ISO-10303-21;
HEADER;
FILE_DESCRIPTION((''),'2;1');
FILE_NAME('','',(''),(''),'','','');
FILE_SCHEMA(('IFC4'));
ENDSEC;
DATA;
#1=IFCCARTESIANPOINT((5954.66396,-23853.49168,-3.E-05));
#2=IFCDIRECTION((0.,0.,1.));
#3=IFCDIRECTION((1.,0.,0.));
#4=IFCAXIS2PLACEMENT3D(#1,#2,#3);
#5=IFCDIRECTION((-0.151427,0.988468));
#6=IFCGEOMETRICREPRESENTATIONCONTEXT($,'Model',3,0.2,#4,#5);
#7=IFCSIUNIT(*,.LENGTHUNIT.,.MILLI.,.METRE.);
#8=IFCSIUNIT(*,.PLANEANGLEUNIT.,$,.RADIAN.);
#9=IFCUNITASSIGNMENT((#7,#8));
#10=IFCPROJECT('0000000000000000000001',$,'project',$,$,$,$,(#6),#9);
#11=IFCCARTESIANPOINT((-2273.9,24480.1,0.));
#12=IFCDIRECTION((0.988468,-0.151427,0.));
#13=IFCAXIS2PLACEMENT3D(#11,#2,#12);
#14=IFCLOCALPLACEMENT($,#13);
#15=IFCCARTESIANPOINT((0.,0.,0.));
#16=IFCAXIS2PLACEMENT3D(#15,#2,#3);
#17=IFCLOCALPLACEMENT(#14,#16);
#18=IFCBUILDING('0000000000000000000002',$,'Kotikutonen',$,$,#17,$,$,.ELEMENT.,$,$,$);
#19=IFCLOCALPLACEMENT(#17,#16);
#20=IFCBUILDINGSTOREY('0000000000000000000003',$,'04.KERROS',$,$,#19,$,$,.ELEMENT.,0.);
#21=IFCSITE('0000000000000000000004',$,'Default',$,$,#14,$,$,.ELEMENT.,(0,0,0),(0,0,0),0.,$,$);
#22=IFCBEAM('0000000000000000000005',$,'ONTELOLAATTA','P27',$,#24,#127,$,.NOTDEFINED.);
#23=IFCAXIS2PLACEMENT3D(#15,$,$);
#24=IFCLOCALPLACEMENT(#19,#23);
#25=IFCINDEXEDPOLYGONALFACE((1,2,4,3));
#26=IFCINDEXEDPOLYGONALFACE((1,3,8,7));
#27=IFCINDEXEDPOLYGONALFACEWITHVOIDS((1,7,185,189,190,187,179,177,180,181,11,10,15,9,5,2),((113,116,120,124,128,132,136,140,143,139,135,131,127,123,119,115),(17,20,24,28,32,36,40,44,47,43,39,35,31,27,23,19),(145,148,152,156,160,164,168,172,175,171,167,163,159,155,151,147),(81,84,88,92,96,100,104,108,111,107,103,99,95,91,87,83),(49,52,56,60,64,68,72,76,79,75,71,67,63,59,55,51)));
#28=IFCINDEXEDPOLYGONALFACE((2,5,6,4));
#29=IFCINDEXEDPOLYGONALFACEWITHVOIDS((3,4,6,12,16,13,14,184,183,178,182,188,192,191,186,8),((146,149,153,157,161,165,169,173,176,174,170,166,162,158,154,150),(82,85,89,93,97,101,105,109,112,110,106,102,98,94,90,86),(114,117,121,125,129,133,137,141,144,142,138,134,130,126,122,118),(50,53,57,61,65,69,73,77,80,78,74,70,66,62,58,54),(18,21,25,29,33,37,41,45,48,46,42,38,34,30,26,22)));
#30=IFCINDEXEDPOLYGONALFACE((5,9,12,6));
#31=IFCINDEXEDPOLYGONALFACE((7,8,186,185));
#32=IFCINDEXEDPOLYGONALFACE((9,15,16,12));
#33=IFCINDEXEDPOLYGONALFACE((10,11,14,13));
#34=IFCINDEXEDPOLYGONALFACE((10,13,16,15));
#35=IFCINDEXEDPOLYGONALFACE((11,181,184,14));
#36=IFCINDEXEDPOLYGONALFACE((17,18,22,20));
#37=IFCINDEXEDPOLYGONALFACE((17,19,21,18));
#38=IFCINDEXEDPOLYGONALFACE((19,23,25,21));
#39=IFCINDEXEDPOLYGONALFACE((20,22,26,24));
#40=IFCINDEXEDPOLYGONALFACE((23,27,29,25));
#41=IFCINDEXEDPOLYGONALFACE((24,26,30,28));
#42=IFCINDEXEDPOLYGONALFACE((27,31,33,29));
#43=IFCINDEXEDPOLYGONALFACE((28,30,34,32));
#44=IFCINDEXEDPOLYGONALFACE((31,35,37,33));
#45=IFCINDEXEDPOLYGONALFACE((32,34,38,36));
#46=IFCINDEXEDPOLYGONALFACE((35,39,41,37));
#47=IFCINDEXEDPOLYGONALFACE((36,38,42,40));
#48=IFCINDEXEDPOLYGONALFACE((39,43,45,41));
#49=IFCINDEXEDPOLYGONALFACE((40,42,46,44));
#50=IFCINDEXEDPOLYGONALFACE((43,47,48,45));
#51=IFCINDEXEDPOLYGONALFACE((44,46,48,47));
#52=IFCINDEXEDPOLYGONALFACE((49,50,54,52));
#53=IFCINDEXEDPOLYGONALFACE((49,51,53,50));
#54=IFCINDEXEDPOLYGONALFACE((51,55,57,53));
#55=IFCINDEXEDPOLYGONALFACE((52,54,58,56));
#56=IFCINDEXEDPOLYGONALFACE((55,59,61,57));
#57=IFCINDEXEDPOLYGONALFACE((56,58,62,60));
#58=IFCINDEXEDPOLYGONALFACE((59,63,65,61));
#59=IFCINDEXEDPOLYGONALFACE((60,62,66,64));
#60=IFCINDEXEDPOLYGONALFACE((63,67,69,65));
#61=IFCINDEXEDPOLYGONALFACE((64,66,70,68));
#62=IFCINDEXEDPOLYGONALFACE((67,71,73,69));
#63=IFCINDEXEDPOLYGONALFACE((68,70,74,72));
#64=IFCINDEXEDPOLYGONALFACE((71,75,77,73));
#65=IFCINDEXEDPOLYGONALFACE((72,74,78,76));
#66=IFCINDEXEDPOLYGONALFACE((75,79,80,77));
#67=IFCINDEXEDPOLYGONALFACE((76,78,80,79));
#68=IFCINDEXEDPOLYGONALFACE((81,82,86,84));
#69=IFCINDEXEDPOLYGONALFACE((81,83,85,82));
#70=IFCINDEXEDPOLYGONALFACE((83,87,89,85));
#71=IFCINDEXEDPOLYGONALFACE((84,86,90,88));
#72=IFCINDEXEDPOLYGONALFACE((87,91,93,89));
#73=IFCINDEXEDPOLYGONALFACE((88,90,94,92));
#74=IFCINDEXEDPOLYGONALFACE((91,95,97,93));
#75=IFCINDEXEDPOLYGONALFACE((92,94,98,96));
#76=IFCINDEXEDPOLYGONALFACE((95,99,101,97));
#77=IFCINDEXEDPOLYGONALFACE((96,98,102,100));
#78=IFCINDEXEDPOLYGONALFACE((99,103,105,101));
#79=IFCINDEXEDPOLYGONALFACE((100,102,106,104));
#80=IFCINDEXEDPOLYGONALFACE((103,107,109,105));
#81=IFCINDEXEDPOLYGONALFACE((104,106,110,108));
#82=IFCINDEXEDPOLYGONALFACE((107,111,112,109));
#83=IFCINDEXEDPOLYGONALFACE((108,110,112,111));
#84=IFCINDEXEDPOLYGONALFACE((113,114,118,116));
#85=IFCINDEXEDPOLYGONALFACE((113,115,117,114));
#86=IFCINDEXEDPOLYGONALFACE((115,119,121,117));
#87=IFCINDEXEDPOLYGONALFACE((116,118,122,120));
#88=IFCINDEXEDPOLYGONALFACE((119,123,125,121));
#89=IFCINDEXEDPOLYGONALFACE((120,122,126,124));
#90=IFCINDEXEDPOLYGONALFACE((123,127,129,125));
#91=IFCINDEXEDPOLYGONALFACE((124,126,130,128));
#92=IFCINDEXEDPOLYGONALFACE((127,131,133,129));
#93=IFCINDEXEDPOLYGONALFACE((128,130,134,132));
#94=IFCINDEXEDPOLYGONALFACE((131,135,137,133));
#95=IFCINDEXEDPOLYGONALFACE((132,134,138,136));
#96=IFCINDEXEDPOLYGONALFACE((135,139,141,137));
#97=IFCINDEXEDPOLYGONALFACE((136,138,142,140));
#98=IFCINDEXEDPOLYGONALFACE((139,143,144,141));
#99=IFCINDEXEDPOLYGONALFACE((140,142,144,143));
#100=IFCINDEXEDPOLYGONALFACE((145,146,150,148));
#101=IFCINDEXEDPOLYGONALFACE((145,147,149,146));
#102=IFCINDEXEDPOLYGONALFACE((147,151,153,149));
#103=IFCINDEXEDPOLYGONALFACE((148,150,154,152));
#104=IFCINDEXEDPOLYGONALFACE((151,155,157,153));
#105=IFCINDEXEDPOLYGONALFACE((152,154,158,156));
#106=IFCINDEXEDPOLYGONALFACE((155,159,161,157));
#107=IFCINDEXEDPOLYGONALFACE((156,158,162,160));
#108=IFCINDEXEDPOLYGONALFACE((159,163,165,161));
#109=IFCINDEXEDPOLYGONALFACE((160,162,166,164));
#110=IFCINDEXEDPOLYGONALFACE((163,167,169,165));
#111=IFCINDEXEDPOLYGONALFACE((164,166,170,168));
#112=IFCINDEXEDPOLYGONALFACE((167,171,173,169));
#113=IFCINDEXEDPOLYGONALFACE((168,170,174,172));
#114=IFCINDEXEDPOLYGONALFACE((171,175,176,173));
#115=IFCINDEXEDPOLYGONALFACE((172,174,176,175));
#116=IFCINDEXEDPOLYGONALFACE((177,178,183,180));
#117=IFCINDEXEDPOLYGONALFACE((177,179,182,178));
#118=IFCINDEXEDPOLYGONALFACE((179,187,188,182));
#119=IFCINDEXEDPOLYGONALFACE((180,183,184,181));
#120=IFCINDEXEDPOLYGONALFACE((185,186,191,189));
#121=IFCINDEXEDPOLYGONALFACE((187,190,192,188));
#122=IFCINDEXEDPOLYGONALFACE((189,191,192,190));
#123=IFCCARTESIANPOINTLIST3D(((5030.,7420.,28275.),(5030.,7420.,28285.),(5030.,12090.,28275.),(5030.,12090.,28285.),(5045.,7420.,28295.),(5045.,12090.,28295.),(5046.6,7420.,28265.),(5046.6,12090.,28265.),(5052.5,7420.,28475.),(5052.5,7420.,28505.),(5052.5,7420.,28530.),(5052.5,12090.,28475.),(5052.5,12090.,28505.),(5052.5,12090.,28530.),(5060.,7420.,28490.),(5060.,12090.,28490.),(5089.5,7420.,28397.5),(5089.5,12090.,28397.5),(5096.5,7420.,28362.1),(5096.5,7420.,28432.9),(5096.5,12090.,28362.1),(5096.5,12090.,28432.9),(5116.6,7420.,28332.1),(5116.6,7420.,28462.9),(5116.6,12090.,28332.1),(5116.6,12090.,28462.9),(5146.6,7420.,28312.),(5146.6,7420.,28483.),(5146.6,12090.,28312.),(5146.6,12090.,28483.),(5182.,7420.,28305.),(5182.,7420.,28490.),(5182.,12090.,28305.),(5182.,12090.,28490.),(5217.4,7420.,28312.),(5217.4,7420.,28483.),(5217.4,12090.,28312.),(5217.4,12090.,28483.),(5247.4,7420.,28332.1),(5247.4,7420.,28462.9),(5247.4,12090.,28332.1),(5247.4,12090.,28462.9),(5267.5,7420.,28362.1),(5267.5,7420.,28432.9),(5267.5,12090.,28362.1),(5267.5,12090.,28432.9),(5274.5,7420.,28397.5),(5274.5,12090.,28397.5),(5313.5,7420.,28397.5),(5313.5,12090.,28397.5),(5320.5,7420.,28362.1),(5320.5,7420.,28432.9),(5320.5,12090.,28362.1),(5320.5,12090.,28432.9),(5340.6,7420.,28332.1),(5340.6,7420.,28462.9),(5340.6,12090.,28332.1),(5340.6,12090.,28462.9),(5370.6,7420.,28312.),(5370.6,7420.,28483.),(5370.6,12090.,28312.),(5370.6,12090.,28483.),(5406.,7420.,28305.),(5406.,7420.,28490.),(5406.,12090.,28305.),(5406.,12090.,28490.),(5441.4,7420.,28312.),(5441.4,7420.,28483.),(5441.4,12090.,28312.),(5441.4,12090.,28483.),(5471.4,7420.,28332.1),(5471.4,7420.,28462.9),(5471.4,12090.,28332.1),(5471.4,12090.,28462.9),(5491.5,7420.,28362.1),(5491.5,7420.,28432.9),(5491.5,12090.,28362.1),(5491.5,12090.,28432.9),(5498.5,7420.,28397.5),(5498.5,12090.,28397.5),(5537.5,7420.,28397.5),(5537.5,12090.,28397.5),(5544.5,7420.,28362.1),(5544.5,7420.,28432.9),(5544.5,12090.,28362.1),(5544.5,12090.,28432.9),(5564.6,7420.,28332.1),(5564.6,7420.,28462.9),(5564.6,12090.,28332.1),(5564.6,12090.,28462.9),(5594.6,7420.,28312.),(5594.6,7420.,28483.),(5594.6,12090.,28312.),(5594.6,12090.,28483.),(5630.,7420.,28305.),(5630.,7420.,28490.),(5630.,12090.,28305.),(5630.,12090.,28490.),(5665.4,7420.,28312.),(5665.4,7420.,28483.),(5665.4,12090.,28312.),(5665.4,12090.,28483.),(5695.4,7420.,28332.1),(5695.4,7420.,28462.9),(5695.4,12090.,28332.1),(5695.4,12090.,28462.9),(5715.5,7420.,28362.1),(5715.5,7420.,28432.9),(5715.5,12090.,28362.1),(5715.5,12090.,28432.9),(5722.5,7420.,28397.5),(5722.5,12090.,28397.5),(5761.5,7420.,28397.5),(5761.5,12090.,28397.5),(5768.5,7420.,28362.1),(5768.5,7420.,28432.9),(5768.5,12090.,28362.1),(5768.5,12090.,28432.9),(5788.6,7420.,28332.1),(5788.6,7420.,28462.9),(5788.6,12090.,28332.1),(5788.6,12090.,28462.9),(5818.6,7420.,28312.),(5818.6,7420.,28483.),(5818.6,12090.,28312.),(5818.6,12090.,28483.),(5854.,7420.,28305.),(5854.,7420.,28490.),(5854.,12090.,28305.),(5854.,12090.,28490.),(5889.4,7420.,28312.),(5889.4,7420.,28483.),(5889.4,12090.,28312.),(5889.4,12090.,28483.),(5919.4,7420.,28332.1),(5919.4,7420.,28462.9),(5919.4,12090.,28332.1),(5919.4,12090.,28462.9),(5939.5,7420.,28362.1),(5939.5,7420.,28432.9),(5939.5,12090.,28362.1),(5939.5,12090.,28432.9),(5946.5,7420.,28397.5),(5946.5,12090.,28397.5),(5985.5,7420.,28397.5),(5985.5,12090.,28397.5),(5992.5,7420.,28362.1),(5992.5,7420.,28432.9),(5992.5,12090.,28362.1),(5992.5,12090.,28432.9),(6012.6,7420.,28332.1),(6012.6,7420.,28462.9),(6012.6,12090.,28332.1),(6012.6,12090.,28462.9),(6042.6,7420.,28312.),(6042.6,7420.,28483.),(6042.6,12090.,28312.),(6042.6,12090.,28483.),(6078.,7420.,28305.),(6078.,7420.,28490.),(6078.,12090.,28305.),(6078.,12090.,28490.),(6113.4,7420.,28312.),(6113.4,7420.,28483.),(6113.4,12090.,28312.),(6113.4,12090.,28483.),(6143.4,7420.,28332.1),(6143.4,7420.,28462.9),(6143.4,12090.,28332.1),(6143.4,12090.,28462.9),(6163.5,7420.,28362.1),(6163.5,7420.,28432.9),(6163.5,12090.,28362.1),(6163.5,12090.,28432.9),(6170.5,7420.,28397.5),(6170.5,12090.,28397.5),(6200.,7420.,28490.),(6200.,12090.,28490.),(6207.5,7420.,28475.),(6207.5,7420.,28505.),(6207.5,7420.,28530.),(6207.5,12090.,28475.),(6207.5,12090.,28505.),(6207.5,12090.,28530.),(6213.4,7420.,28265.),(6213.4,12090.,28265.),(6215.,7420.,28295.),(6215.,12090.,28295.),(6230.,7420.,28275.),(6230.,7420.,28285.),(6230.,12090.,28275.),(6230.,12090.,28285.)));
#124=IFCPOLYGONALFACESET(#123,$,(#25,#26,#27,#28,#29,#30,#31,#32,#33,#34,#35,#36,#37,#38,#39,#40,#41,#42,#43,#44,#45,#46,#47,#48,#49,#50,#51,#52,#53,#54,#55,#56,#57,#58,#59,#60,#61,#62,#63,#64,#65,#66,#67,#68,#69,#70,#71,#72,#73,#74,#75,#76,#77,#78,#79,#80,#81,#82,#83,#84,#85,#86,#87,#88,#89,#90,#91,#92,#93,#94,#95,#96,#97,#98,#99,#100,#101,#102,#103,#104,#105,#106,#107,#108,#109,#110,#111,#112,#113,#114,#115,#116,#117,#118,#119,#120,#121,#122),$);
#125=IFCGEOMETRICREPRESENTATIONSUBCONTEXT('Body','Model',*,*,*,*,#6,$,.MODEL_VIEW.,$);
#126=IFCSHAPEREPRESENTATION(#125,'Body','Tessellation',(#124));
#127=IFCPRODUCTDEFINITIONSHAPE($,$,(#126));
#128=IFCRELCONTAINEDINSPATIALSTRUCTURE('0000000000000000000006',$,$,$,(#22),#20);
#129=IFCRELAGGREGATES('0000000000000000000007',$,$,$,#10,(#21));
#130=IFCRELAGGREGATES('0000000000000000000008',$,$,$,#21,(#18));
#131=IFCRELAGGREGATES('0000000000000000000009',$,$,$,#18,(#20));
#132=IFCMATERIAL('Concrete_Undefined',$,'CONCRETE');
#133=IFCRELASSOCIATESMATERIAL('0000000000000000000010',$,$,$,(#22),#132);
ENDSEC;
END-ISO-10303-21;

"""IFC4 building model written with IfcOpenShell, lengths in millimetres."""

from ifc_helpers import new_model, si_unit, direction, frame, origin_with_axes, place, context, subcontext, project, spatial, line, indexed_curve, outline, extrude, material, element, save


model = new_model("IFC4")

# Units and contexts
model_context = context("Model", 3, precision=0.2, world=frame((5954.66396, -23853.49168, -3e-05), z_axis=(0.0, 0.0, 1.0), x_axis=(1.0, 0.0, 0.0)), true_north=direction((-0.151427, 0.988468)))
body_context = subcontext(model_context, "Body", "Model", "MODEL_VIEW")
ifc_project = project(units=[si_unit("LENGTHUNIT", "METRE", prefix="MILLI"), si_unit("PLANEANGLEUNIT", "RADIAN")], contexts=[model_context])

# Site, building, storey
site_placement = place(None, frame((-2273.9, 24480.1, 0.0), z_axis=(0.0, 0.0, 1.0), x_axis=(0.988468, -0.151427, 0.0)))
site = spatial("IfcSite", under=ifc_project, at=site_placement, Name="Default", CompositionType="ELEMENT", RefLatitude=(0, 0, 0), RefLongitude=(0, 0, 0), RefElevation=0.0)
building_placement = place(site_placement, origin_with_axes())
building = spatial("IfcBuilding", under=site, at=building_placement, Name="Kotikutonen", CompositionType="ELEMENT")
storey_placement = place(building_placement, origin_with_axes())
storey = spatial("IfcBuildingStorey", under=building, at=storey_placement, Name="04.KERROS", CompositionType="ELEMENT", Elevation=0.0)

# Beam
ifc_material_1 = material(Name="Concrete_Undefined", Category="CONCRETE")
beam_1_placement = place(storey_placement, frame((5630.0, 12090.0, 28397.5), z_axis=(-1.0, 0.0, 0.0), x_axis=(0.0, -1.0, 0.0)))
element("IfcBeam", 1, at=beam_1_placement, inside=storey, material=ifc_material_1, Name="ONTELOLAATTA", Description="P27", PredefinedType="NOTDEFINED", context=body_context, shape_type="SolidModel", body=[
    extrude(outline(indexed_curve([(-600.0, -122.5), (-583.4, -132.5), (583.4, -132.5), (600.0, -122.5), (600.0, -112.5), (585.0, -102.5), (577.5, 77.5), (570.0, 92.5), (577.5, 107.5), (577.5, 132.5), (-577.5, 132.5), (-577.5, 107.5), (-570.0, 92.5), (-577.5, 77.5), (-585.0, -102.5), (-600.0, -112.5)], segments=[line(1, 2, 3, 4, 5, 6, 7, 8, 9, 10, 11, 12, 13, 14, 15, 16, 1)]), holes=[indexed_curve([(-448.0, -92.5), (-483.4, -85.5), (-513.4, -65.4), (-533.5, -35.4), (-540.5, 0.0), (-533.5, 35.4), (-513.4, 65.4), (-483.4, 85.5), (-448.0, 92.5), (-412.6, 85.5), (-382.6, 65.4), (-362.5, 35.4), (-355.5, 0.0), (-362.5, -35.4), (-382.6, -65.4), (-412.6, -85.5)], segments=[line(1, 2, 3, 4, 5, 6, 7, 8, 9, 10, 11, 12, 13, 14, 15, 16, 1)]), indexed_curve([(-224.0, -92.5), (-259.4, -85.5), (-289.4, -65.4), (-309.5, -35.4), (-316.5, 0.0), (-309.5, 35.4), (-289.4, 65.4), (-259.4, 85.5), (-224.0, 92.5), (-188.6, 85.5), (-158.6, 65.4), (-138.5, 35.4), (-131.5, 0.0), (-138.5, -35.4), (-158.6, -65.4), (-188.6, -85.5)], segments=[line(1, 2, 3, 4, 5, 6, 7, 8, 9, 10, 11, 12, 13, 14, 15, 16, 1)]), indexed_curve([(0.0, -92.5), (-35.4, -85.5), (-65.4, -65.4), (-85.5, -35.4), (-92.5, 0.0), (-85.5, 35.4), (-65.4, 65.4), (-35.4, 85.5), (0.0, 92.5), (35.4, 85.5), (65.4, 65.4), (85.5, 35.4), (92.5, 0.0), (85.5, -35.4), (65.4, -65.4), (35.4, -85.5)], segments=[line(1, 2, 3, 4, 5, 6, 7, 8, 9, 10, 11, 12, 13, 14, 15, 16, 1)]), indexed_curve([(224.0, -92.5), (188.6, -85.5), (158.6, -65.4), (138.5, -35.4), (131.5, 0.0), (138.5, 35.4), (158.6, 65.4), (188.6, 85.5), (224.0, 92.5), (259.4, 85.5), (289.4, 65.4), (309.5, 35.4), (316.5, 0.0), (309.5, -35.4), (289.4, -65.4), (259.4, -85.5)], segments=[line(1, 2, 3, 4, 5, 6, 7, 8, 9, 10, 11, 12, 13, 14, 15, 16, 1)]), indexed_curve([(448.0, -92.5), (412.6, -85.5), (382.6, -65.4), (362.5, -35.4), (355.5, 0.0), (362.5, 35.4), (382.6, 65.4), (412.6, 85.5), (448.0, 92.5), (483.4, 85.5), (513.4, 65.4), (533.5, 35.4), (540.5, 0.0), (533.5, -35.4), (513.4, -65.4), (483.4, -85.5)], segments=[line(1, 2, 3, 4, 5, 6, 7, 8, 9, 10, 11, 12, 13, 14, 15, 16, 1)])]), frame((0.0, 0.0, 0.0), z_axis=(-1.0, 0.0, 0.0), x_axis=(0.0, 0.0, 1.0)), (0.0, 0.0, -1.0), 4670.0),
])

save(model, "model.ifc")
